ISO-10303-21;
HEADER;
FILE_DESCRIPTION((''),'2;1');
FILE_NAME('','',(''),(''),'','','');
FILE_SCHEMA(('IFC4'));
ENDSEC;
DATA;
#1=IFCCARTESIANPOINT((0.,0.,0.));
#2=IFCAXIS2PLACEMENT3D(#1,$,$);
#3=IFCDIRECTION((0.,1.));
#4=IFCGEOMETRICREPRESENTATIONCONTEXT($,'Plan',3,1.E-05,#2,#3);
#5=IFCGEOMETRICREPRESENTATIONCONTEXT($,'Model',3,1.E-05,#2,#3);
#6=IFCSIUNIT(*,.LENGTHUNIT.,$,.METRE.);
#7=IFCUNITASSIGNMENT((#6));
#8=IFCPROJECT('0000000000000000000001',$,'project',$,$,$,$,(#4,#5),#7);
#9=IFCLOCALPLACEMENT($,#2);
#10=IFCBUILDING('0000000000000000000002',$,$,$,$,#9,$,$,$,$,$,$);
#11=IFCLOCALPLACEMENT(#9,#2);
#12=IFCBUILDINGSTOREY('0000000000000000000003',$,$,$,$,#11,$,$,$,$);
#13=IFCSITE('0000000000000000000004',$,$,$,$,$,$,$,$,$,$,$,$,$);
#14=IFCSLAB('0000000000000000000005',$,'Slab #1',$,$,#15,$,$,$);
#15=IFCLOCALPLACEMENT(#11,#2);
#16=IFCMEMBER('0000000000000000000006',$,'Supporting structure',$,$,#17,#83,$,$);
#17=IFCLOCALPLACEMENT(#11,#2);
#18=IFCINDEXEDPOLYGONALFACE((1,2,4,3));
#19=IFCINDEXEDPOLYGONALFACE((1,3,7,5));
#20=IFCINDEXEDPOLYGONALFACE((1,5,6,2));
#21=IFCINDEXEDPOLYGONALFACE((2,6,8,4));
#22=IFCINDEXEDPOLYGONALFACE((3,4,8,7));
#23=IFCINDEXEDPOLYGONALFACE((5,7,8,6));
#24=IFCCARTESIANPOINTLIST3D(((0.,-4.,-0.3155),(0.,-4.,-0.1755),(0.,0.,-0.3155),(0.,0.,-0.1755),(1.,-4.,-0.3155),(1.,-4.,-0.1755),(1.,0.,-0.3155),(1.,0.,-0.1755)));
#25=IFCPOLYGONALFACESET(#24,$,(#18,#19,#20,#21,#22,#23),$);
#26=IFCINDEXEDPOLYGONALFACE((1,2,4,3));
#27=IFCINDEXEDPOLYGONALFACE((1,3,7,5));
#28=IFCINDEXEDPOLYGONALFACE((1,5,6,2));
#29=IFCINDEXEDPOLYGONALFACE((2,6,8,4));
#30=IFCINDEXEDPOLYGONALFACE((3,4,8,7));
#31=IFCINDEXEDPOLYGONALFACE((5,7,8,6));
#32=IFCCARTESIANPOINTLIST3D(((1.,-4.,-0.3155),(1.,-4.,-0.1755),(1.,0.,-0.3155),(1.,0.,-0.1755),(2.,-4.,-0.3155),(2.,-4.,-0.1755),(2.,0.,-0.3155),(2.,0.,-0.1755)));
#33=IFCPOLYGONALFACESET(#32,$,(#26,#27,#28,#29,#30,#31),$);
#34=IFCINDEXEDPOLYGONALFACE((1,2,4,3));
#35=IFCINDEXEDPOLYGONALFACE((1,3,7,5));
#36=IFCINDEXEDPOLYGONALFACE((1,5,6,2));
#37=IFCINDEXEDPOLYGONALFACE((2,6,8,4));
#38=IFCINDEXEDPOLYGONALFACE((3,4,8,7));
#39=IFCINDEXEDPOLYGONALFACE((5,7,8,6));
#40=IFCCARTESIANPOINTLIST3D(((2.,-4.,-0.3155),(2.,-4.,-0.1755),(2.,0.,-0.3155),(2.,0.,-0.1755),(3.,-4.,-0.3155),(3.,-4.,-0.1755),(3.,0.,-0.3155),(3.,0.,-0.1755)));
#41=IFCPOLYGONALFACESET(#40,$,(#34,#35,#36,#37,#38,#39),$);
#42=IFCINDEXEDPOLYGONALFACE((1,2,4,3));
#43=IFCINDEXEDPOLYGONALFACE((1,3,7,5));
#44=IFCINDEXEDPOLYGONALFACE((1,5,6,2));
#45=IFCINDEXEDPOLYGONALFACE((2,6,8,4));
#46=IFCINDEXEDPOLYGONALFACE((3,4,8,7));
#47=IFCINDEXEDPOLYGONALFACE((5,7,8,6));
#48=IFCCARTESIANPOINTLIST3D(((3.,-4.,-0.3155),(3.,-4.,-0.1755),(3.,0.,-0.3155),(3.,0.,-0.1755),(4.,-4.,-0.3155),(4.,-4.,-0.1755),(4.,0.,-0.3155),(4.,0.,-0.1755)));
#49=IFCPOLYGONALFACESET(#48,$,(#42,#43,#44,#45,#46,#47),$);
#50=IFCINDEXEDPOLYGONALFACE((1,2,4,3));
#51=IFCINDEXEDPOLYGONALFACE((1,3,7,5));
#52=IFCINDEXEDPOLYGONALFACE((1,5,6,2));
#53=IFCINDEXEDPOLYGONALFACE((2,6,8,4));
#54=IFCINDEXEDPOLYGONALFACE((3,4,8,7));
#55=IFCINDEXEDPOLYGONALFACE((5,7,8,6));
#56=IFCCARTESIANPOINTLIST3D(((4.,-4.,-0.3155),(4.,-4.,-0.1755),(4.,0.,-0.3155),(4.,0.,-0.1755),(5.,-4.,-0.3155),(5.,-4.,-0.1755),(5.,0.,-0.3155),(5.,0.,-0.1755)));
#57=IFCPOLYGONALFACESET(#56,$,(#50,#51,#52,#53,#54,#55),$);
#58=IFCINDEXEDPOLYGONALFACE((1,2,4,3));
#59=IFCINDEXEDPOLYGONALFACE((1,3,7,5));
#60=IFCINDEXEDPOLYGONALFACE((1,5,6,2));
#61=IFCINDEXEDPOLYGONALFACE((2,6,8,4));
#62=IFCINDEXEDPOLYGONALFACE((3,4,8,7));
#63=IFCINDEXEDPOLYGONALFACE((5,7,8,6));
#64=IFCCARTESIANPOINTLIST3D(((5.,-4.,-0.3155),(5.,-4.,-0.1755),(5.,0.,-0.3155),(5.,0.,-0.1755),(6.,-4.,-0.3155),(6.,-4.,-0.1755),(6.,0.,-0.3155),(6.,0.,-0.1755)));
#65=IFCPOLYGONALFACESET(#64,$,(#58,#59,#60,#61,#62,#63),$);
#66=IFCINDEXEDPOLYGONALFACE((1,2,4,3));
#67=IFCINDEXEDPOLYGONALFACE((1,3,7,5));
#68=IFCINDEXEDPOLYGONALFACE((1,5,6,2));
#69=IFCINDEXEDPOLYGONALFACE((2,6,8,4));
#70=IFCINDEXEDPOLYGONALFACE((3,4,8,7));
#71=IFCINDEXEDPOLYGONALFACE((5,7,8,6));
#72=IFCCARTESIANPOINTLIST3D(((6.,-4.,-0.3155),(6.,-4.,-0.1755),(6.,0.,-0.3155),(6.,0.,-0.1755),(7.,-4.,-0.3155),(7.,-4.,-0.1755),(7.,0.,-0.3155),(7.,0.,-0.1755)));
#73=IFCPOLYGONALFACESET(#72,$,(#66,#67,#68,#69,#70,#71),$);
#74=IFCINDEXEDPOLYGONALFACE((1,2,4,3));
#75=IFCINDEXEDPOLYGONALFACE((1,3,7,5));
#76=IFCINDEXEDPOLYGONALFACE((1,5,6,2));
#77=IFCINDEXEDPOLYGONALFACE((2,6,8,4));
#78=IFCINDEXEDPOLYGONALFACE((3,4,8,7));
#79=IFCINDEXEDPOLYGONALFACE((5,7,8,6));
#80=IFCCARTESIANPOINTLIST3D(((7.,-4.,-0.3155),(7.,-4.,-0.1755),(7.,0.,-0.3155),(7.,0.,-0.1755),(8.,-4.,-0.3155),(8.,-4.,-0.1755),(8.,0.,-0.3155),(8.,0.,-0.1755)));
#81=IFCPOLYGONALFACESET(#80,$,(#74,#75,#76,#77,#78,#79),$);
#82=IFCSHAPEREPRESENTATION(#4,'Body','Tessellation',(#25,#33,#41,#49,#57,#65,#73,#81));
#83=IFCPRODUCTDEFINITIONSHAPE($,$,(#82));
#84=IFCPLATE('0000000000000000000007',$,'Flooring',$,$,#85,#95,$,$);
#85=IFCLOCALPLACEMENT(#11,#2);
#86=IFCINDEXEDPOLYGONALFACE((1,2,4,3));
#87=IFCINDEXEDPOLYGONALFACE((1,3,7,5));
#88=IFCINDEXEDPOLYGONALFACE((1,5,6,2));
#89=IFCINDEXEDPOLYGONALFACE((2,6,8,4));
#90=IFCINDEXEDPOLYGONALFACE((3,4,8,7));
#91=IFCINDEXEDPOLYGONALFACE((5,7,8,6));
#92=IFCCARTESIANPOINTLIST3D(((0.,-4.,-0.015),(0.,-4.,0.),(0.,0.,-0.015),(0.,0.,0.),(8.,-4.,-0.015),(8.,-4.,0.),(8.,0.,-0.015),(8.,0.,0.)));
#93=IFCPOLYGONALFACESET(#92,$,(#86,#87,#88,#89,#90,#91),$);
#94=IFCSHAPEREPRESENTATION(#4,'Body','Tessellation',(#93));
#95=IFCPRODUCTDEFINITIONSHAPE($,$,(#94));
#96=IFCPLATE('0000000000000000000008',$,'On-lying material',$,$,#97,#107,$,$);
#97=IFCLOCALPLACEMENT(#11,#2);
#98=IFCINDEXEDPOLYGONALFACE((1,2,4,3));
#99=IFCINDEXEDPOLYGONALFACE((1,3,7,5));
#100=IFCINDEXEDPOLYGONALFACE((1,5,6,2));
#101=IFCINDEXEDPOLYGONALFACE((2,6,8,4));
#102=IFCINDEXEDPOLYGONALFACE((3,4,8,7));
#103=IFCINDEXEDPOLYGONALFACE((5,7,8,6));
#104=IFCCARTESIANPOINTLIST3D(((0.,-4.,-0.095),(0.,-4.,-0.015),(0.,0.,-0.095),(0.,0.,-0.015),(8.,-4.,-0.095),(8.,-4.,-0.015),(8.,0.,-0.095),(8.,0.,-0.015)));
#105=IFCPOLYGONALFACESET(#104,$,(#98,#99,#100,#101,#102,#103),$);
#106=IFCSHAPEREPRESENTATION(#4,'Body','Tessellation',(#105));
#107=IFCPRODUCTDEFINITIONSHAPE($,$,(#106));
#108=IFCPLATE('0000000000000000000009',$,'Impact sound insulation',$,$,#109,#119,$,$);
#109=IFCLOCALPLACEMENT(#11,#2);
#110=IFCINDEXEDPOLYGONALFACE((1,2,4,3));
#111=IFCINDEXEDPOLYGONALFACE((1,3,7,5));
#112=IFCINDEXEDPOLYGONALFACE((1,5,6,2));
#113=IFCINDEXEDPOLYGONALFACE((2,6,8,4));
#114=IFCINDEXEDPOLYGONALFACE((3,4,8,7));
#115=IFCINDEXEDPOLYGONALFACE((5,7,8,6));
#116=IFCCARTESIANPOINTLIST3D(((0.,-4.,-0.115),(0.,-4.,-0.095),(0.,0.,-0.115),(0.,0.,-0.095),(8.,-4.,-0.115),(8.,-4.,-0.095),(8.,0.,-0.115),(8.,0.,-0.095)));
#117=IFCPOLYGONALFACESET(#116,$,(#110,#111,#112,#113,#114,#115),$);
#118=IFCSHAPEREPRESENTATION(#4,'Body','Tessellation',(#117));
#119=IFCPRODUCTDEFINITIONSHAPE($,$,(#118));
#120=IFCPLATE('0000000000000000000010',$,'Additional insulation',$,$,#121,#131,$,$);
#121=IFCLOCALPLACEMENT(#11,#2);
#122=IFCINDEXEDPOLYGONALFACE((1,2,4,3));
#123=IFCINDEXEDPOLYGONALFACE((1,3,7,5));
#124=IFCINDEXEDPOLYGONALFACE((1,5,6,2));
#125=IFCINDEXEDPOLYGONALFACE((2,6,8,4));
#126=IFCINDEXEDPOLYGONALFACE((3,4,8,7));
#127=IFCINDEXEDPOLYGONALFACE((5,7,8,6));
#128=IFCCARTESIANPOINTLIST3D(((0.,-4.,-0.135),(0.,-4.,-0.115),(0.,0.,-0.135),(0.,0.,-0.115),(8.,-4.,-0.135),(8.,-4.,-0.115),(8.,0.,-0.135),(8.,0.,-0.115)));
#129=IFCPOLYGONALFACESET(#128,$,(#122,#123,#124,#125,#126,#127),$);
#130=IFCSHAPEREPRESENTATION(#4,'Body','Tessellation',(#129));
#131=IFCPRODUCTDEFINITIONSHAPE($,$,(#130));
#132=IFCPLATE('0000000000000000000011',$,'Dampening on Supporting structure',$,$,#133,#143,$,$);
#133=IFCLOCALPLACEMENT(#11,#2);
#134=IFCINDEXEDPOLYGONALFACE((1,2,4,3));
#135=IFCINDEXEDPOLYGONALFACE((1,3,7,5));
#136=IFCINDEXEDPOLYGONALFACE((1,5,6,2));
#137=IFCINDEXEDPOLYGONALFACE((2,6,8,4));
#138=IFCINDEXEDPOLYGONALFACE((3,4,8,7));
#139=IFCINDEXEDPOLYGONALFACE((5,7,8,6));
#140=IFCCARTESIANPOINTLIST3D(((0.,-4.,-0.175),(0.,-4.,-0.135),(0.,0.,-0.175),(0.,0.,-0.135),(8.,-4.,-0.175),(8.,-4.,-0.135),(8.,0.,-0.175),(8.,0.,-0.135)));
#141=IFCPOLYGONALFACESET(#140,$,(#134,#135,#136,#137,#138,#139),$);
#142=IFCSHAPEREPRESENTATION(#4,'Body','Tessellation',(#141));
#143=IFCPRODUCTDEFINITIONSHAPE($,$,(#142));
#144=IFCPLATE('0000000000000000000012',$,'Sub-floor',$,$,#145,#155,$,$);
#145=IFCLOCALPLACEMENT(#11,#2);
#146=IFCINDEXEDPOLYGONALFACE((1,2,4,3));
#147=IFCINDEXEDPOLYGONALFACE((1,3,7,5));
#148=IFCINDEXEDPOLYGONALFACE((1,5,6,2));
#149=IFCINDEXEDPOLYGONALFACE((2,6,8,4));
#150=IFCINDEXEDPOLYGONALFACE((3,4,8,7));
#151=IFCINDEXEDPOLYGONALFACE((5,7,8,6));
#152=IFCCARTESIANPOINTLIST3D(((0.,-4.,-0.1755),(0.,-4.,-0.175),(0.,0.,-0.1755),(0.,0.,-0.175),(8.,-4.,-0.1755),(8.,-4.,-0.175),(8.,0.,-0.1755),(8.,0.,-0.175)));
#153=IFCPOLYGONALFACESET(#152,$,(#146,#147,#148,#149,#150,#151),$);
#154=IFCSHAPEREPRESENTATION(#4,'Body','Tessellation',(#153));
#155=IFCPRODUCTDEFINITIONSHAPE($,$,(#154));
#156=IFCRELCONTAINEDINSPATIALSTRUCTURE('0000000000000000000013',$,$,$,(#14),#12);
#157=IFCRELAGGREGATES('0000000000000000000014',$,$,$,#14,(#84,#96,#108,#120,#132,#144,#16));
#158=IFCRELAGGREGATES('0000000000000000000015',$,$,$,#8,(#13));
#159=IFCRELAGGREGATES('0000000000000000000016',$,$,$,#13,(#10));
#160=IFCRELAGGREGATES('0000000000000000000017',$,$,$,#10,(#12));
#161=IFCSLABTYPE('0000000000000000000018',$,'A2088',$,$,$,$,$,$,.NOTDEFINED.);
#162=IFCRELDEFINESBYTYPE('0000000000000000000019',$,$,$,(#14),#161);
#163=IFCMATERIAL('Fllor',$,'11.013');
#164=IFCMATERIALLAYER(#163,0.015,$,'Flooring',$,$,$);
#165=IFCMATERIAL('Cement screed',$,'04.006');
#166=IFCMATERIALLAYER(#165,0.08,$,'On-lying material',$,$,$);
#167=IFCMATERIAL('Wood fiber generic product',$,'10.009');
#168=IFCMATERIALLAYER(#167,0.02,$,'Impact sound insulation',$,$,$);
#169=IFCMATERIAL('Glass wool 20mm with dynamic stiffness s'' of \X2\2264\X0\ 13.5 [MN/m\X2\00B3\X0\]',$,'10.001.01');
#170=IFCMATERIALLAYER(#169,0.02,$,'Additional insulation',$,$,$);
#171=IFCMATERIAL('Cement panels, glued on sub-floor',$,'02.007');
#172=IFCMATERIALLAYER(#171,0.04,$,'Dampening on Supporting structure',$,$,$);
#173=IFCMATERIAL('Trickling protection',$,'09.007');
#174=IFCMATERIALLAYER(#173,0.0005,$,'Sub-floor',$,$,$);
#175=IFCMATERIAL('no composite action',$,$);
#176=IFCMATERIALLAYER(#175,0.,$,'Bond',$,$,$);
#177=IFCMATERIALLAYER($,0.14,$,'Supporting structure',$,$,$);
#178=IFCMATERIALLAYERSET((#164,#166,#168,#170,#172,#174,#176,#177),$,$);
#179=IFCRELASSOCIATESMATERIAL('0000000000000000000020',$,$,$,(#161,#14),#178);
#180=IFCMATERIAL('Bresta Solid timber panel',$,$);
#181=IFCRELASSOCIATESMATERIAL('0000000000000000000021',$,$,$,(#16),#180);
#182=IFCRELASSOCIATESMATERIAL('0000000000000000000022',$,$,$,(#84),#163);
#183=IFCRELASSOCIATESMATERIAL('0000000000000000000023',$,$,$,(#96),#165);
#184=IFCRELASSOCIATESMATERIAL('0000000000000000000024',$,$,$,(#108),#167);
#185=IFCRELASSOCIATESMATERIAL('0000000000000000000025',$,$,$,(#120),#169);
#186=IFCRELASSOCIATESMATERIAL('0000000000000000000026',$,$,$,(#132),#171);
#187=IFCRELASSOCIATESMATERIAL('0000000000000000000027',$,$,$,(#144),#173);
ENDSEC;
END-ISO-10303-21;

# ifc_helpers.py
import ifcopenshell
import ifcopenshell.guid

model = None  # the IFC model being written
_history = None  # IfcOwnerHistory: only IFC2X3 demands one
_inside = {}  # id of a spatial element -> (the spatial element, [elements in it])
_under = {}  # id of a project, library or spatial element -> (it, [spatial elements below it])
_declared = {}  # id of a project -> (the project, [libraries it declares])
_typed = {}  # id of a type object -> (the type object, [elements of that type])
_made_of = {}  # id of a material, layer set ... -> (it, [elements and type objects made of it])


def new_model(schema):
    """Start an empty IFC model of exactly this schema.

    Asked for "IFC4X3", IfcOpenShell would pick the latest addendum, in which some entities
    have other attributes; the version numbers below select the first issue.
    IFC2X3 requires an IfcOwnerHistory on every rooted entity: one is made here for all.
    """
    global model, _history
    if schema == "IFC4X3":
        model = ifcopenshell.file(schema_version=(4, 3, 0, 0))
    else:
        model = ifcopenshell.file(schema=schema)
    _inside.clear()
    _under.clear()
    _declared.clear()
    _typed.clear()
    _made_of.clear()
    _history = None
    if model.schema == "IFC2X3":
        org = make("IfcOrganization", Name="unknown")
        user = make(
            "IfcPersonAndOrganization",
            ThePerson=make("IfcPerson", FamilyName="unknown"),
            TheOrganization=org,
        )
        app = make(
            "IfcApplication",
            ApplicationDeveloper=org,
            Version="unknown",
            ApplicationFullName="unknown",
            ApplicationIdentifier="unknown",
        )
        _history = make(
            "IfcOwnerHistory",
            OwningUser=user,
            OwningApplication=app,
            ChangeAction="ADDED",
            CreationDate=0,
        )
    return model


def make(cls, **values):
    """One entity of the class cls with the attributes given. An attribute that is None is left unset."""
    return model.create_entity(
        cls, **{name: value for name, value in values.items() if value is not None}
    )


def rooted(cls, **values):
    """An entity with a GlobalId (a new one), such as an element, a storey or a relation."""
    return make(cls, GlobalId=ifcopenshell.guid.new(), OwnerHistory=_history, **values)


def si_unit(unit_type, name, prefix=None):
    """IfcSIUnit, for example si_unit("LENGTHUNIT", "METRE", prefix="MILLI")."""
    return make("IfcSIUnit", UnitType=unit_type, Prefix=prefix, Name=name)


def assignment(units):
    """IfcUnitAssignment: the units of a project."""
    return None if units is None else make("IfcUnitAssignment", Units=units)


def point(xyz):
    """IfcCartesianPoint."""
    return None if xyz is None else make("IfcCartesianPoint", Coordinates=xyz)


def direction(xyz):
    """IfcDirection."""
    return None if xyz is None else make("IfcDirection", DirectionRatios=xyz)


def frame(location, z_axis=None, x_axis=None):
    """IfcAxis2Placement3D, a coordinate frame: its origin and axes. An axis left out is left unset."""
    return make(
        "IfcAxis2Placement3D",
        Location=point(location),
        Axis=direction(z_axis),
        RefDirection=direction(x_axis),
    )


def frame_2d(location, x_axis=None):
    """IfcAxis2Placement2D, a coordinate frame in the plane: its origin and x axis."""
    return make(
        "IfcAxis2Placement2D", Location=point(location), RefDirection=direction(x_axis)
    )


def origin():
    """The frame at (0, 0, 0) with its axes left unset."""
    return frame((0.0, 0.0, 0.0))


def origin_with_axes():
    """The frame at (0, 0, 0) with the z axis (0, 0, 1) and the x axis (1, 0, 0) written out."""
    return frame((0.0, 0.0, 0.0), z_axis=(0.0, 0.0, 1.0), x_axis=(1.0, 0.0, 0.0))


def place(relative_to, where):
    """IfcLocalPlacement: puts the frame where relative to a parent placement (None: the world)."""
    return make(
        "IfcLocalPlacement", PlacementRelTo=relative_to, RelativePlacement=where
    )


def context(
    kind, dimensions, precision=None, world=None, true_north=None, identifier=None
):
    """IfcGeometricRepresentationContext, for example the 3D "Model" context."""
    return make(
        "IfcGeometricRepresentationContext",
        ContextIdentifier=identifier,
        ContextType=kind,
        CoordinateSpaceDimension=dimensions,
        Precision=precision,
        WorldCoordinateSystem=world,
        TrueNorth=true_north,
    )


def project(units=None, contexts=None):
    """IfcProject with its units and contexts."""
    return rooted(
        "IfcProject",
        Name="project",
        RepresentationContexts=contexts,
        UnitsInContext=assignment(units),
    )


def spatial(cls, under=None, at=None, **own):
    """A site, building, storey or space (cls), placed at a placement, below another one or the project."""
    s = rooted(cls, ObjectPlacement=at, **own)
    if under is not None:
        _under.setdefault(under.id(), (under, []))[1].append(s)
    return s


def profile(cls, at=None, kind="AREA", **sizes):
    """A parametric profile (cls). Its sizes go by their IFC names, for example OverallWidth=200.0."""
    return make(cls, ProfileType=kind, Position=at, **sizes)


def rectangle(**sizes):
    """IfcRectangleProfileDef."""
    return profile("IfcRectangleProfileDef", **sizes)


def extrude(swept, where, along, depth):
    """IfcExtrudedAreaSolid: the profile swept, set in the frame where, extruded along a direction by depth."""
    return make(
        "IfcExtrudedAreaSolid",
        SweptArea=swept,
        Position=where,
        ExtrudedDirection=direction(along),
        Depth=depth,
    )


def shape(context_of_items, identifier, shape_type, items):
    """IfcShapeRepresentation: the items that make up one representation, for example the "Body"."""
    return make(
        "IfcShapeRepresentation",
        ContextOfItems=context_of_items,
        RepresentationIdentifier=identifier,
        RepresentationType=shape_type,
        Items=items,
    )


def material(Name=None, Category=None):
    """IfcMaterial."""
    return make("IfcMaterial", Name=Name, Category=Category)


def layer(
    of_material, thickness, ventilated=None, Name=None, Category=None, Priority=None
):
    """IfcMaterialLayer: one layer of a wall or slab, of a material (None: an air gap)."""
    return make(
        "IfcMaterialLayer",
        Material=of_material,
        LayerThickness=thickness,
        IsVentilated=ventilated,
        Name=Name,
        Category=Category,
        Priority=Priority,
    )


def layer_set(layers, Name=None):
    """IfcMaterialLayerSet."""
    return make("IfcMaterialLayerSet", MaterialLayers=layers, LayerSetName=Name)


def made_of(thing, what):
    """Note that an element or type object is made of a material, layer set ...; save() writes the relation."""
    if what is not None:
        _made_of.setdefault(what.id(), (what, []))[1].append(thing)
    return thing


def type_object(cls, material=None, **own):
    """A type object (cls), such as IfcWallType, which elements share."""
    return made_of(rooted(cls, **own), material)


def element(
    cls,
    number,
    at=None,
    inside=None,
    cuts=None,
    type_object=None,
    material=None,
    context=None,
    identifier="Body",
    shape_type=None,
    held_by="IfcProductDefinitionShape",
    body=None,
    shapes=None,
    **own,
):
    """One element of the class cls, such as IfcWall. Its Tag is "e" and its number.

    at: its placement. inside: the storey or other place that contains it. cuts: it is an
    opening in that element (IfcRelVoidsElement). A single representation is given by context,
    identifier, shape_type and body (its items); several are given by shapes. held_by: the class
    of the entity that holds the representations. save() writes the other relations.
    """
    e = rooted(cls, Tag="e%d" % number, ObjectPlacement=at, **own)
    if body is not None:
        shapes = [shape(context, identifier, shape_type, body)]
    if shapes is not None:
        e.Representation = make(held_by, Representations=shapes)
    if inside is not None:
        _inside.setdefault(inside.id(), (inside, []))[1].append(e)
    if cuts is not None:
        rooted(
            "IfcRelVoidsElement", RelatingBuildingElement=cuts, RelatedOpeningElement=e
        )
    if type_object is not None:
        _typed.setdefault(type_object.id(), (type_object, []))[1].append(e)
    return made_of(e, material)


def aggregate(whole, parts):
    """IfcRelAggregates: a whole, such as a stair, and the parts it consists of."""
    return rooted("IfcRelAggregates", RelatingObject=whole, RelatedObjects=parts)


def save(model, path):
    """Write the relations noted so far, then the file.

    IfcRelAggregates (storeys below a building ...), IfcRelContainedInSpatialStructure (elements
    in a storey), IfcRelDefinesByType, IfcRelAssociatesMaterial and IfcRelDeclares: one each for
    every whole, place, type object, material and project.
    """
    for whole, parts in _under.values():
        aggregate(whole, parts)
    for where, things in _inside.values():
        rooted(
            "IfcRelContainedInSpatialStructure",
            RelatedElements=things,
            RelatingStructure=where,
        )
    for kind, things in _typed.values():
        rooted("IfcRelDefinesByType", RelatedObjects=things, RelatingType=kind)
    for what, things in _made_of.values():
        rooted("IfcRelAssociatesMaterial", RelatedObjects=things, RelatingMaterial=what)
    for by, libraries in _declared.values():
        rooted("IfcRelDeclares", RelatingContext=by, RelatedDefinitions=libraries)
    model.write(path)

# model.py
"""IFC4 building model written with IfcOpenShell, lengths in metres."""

from ifc_helpers import new_model, si_unit, direction, frame, frame_2d, origin, origin_with_axes, place, context, project, spatial, rectangle, extrude, material, layer, layer_set, type_object, element, aggregate, save


model = new_model("IFC4")

# Units and contexts
plan_context = context("Plan", 3, precision=1e-05, world=origin(), true_north=direction((0.0, 1.0)))
model_context = context("Model", 3, precision=1e-05, world=origin(), true_north=direction((0.0, 1.0)))
ifc_project = project(units=[si_unit("LENGTHUNIT", "METRE")], contexts=[plan_context, model_context])

# Site, building, storey
site = spatial("IfcSite", under=ifc_project)
building_placement = place(None, origin())
building = spatial("IfcBuilding", under=site, at=building_placement)
storey_placement = place(building_placement, origin())
storey = spatial("IfcBuildingStorey", under=building, at=storey_placement)

# Slab, member, plates
ifc_material_1 = material(Name="Fllor", Category="11.013")
ifc_layer_1 = layer(ifc_material_1, 0.015, Name="Flooring")
ifc_material_2 = material(Name="Cement screed", Category="04.006")
ifc_layer_2 = layer(ifc_material_2, 0.08, Name="On-lying material")
ifc_material_3 = material(Name="Wood fiber generic product", Category="10.009")
ifc_layer_3 = layer(ifc_material_3, 0.02, Name="Impact sound insulation")
ifc_material_4 = material(Name="Glass wool 20mm with dynamic stiffness s' of ≤ 13.5 [MN/m³]", Category="10.001.01")
ifc_layer_4 = layer(ifc_material_4, 0.02, Name="Additional insulation")
ifc_material_5 = material(Name="Cement panels, glued on sub-floor", Category="02.007")
ifc_layer_5 = layer(ifc_material_5, 0.04, Name="Dampening on Supporting structure")
ifc_material_6 = material(Name="Trickling protection", Category="09.007")
ifc_layer_6 = layer(ifc_material_6, 0.0005, Name="Sub-floor")
ifc_material_7 = material(Name="no composite action")
ifc_layer_7 = layer(ifc_material_7, 0.0, Name="Bond")
ifc_layer_8 = layer(None, 0.14, Name="Supporting structure")
ifc_layer_set = layer_set([ifc_layer_1, ifc_layer_2, ifc_layer_3, ifc_layer_4, ifc_layer_5, ifc_layer_6, ifc_layer_7, ifc_layer_8])
slab_type = type_object("IfcSlabType", Name="A2088", PredefinedType="NOTDEFINED", material=ifc_layer_set)
slab_placement = place(None, frame((0.0, 0.0, 0.0), z_axis=(0.0, 0.0, -1.0), x_axis=(1.0, 0.0, 0.0)))
slab = element("IfcSlab", 1, at=slab_placement, inside=storey, type_object=slab_type, material=ifc_layer_set, Name="Slab #1")
ifc_material_8 = material(Name="Bresta Solid timber panel")
member_placement = place(slab_placement, origin())
member = element("IfcMember", 2, at=member_placement, material=ifc_material_8, Name="Supporting structure", context=plan_context, shape_type="SweptSolid", body=[
    extrude(rectangle(XDim=1.0, YDim=0.14, at=frame_2d((0.5, 0.07), x_axis=(1.0, 0.0))), frame((0.0, 4.0, 0.1755), z_axis=(0.0, -1.0, 0.0), x_axis=(1.0, 0.0, 0.0)), (0.0, 0.0, 1.0), 4.0),
    extrude(rectangle(XDim=1.0, YDim=0.14, at=frame_2d((0.5, 0.07), x_axis=(1.0, 0.0))), frame((1.0, 4.0, 0.1755), z_axis=(0.0, -1.0, 0.0), x_axis=(1.0, 0.0, 0.0)), (0.0, 0.0, 1.0), 4.0),
    extrude(rectangle(XDim=1.0, YDim=0.14, at=frame_2d((0.5, 0.07), x_axis=(1.0, 0.0))), frame((2.0, 4.0, 0.1755), z_axis=(0.0, -1.0, 0.0), x_axis=(1.0, 0.0, 0.0)), (0.0, 0.0, 1.0), 4.0),
    extrude(rectangle(XDim=1.0, YDim=0.14, at=frame_2d((0.5, 0.07), x_axis=(1.0, 0.0))), frame((3.0, 4.0, 0.1755), z_axis=(0.0, -1.0, 0.0), x_axis=(1.0, 0.0, 0.0)), (0.0, 0.0, 1.0), 4.0),
    extrude(rectangle(XDim=1.0, YDim=0.14, at=frame_2d((0.5, 0.07), x_axis=(1.0, 0.0))), frame((4.0, 4.0, 0.1755), z_axis=(0.0, -1.0, 0.0), x_axis=(1.0, 0.0, 0.0)), (0.0, 0.0, 1.0), 4.0),
    extrude(rectangle(XDim=1.0, YDim=0.14, at=frame_2d((0.5, 0.07), x_axis=(1.0, 0.0))), frame((5.0, 4.0, 0.1755), z_axis=(0.0, -1.0, 0.0), x_axis=(1.0, 0.0, 0.0)), (0.0, 0.0, 1.0), 4.0),
    extrude(rectangle(XDim=1.0, YDim=0.14, at=frame_2d((0.5, 0.07), x_axis=(1.0, 0.0))), frame((6.0, 4.0, 0.1755), z_axis=(0.0, -1.0, 0.0), x_axis=(1.0, 0.0, 0.0)), (0.0, 0.0, 1.0), 4.0),
    extrude(rectangle(XDim=1.0, YDim=0.14, at=frame_2d((0.5, 0.07), x_axis=(1.0, 0.0))), frame((7.0, 4.0, 0.1755), z_axis=(0.0, -1.0, 0.0), x_axis=(1.0, 0.0, 0.0)), (0.0, 0.0, 1.0), 4.0),
])
plate_1_placement = place(slab_placement, origin())
plate_1 = element("IfcPlate", 3, at=plate_1_placement, material=ifc_material_1, Name="Flooring", context=plan_context, shape_type="SweptSolid", body=[
    extrude(rectangle(XDim=8.0, YDim=4.0, at=frame_2d((4.0, 2.0), x_axis=(1.0, 0.0))), origin_with_axes(), (0.0, 0.0, 1.0), 0.015),
])
plate_2_placement = place(slab_placement, origin())
plate_2 = element("IfcPlate", 4, at=plate_2_placement, material=ifc_material_2, Name="On-lying material", context=plan_context, shape_type="SweptSolid", body=[
    extrude(rectangle(XDim=8.0, YDim=4.0, at=frame_2d((4.0, 2.0), x_axis=(1.0, 0.0))), frame((0.0, 0.0, 0.015), z_axis=(0.0, 0.0, 1.0), x_axis=(1.0, 0.0, 0.0)), (0.0, 0.0, 1.0), 0.08),
])
plate_3_placement = place(slab_placement, origin())
plate_3 = element("IfcPlate", 5, at=plate_3_placement, material=ifc_material_3, Name="Impact sound insulation", context=plan_context, shape_type="SweptSolid", body=[
    extrude(rectangle(XDim=8.0, YDim=4.0, at=frame_2d((4.0, 2.0), x_axis=(1.0, 0.0))), frame((0.0, 0.0, 0.095), z_axis=(0.0, 0.0, 1.0), x_axis=(1.0, 0.0, 0.0)), (0.0, 0.0, 1.0), 0.02),
])
plate_4_placement = place(slab_placement, origin())
plate_4 = element("IfcPlate", 6, at=plate_4_placement, material=ifc_material_4, Name="Additional insulation", context=plan_context, shape_type="SweptSolid", body=[
    extrude(rectangle(XDim=8.0, YDim=4.0, at=frame_2d((4.0, 2.0), x_axis=(1.0, 0.0))), frame((0.0, 0.0, 0.115), z_axis=(0.0, 0.0, 1.0), x_axis=(1.0, 0.0, 0.0)), (0.0, 0.0, 1.0), 0.02),
])
plate_5_placement = place(slab_placement, origin())
plate_5 = element("IfcPlate", 7, at=plate_5_placement, material=ifc_material_5, Name="Dampening on Supporting structure", context=plan_context, shape_type="SweptSolid", body=[
    extrude(rectangle(XDim=8.0, YDim=4.0, at=frame_2d((4.0, 2.0), x_axis=(1.0, 0.0))), frame((0.0, 0.0, 0.135), z_axis=(0.0, 0.0, 1.0), x_axis=(1.0, 0.0, 0.0)), (0.0, 0.0, 1.0), 0.04),
])
plate_6_placement = place(slab_placement, origin())
plate_6 = element("IfcPlate", 8, at=plate_6_placement, material=ifc_material_6, Name="Sub-floor", context=plan_context, shape_type="SweptSolid", body=[
    extrude(rectangle(XDim=8.0, YDim=4.0, at=frame_2d((4.0, 2.0), x_axis=(1.0, 0.0))), frame((0.0, 0.0, 0.175), z_axis=(0.0, 0.0, 1.0), x_axis=(1.0, 0.0, 0.0)), (0.0, 0.0, 1.0), 0.0005),
])
aggregate(slab, [plate_1, plate_2, plate_3, plate_4, plate_5, plate_6, member])

save(model, "model.ifc")
